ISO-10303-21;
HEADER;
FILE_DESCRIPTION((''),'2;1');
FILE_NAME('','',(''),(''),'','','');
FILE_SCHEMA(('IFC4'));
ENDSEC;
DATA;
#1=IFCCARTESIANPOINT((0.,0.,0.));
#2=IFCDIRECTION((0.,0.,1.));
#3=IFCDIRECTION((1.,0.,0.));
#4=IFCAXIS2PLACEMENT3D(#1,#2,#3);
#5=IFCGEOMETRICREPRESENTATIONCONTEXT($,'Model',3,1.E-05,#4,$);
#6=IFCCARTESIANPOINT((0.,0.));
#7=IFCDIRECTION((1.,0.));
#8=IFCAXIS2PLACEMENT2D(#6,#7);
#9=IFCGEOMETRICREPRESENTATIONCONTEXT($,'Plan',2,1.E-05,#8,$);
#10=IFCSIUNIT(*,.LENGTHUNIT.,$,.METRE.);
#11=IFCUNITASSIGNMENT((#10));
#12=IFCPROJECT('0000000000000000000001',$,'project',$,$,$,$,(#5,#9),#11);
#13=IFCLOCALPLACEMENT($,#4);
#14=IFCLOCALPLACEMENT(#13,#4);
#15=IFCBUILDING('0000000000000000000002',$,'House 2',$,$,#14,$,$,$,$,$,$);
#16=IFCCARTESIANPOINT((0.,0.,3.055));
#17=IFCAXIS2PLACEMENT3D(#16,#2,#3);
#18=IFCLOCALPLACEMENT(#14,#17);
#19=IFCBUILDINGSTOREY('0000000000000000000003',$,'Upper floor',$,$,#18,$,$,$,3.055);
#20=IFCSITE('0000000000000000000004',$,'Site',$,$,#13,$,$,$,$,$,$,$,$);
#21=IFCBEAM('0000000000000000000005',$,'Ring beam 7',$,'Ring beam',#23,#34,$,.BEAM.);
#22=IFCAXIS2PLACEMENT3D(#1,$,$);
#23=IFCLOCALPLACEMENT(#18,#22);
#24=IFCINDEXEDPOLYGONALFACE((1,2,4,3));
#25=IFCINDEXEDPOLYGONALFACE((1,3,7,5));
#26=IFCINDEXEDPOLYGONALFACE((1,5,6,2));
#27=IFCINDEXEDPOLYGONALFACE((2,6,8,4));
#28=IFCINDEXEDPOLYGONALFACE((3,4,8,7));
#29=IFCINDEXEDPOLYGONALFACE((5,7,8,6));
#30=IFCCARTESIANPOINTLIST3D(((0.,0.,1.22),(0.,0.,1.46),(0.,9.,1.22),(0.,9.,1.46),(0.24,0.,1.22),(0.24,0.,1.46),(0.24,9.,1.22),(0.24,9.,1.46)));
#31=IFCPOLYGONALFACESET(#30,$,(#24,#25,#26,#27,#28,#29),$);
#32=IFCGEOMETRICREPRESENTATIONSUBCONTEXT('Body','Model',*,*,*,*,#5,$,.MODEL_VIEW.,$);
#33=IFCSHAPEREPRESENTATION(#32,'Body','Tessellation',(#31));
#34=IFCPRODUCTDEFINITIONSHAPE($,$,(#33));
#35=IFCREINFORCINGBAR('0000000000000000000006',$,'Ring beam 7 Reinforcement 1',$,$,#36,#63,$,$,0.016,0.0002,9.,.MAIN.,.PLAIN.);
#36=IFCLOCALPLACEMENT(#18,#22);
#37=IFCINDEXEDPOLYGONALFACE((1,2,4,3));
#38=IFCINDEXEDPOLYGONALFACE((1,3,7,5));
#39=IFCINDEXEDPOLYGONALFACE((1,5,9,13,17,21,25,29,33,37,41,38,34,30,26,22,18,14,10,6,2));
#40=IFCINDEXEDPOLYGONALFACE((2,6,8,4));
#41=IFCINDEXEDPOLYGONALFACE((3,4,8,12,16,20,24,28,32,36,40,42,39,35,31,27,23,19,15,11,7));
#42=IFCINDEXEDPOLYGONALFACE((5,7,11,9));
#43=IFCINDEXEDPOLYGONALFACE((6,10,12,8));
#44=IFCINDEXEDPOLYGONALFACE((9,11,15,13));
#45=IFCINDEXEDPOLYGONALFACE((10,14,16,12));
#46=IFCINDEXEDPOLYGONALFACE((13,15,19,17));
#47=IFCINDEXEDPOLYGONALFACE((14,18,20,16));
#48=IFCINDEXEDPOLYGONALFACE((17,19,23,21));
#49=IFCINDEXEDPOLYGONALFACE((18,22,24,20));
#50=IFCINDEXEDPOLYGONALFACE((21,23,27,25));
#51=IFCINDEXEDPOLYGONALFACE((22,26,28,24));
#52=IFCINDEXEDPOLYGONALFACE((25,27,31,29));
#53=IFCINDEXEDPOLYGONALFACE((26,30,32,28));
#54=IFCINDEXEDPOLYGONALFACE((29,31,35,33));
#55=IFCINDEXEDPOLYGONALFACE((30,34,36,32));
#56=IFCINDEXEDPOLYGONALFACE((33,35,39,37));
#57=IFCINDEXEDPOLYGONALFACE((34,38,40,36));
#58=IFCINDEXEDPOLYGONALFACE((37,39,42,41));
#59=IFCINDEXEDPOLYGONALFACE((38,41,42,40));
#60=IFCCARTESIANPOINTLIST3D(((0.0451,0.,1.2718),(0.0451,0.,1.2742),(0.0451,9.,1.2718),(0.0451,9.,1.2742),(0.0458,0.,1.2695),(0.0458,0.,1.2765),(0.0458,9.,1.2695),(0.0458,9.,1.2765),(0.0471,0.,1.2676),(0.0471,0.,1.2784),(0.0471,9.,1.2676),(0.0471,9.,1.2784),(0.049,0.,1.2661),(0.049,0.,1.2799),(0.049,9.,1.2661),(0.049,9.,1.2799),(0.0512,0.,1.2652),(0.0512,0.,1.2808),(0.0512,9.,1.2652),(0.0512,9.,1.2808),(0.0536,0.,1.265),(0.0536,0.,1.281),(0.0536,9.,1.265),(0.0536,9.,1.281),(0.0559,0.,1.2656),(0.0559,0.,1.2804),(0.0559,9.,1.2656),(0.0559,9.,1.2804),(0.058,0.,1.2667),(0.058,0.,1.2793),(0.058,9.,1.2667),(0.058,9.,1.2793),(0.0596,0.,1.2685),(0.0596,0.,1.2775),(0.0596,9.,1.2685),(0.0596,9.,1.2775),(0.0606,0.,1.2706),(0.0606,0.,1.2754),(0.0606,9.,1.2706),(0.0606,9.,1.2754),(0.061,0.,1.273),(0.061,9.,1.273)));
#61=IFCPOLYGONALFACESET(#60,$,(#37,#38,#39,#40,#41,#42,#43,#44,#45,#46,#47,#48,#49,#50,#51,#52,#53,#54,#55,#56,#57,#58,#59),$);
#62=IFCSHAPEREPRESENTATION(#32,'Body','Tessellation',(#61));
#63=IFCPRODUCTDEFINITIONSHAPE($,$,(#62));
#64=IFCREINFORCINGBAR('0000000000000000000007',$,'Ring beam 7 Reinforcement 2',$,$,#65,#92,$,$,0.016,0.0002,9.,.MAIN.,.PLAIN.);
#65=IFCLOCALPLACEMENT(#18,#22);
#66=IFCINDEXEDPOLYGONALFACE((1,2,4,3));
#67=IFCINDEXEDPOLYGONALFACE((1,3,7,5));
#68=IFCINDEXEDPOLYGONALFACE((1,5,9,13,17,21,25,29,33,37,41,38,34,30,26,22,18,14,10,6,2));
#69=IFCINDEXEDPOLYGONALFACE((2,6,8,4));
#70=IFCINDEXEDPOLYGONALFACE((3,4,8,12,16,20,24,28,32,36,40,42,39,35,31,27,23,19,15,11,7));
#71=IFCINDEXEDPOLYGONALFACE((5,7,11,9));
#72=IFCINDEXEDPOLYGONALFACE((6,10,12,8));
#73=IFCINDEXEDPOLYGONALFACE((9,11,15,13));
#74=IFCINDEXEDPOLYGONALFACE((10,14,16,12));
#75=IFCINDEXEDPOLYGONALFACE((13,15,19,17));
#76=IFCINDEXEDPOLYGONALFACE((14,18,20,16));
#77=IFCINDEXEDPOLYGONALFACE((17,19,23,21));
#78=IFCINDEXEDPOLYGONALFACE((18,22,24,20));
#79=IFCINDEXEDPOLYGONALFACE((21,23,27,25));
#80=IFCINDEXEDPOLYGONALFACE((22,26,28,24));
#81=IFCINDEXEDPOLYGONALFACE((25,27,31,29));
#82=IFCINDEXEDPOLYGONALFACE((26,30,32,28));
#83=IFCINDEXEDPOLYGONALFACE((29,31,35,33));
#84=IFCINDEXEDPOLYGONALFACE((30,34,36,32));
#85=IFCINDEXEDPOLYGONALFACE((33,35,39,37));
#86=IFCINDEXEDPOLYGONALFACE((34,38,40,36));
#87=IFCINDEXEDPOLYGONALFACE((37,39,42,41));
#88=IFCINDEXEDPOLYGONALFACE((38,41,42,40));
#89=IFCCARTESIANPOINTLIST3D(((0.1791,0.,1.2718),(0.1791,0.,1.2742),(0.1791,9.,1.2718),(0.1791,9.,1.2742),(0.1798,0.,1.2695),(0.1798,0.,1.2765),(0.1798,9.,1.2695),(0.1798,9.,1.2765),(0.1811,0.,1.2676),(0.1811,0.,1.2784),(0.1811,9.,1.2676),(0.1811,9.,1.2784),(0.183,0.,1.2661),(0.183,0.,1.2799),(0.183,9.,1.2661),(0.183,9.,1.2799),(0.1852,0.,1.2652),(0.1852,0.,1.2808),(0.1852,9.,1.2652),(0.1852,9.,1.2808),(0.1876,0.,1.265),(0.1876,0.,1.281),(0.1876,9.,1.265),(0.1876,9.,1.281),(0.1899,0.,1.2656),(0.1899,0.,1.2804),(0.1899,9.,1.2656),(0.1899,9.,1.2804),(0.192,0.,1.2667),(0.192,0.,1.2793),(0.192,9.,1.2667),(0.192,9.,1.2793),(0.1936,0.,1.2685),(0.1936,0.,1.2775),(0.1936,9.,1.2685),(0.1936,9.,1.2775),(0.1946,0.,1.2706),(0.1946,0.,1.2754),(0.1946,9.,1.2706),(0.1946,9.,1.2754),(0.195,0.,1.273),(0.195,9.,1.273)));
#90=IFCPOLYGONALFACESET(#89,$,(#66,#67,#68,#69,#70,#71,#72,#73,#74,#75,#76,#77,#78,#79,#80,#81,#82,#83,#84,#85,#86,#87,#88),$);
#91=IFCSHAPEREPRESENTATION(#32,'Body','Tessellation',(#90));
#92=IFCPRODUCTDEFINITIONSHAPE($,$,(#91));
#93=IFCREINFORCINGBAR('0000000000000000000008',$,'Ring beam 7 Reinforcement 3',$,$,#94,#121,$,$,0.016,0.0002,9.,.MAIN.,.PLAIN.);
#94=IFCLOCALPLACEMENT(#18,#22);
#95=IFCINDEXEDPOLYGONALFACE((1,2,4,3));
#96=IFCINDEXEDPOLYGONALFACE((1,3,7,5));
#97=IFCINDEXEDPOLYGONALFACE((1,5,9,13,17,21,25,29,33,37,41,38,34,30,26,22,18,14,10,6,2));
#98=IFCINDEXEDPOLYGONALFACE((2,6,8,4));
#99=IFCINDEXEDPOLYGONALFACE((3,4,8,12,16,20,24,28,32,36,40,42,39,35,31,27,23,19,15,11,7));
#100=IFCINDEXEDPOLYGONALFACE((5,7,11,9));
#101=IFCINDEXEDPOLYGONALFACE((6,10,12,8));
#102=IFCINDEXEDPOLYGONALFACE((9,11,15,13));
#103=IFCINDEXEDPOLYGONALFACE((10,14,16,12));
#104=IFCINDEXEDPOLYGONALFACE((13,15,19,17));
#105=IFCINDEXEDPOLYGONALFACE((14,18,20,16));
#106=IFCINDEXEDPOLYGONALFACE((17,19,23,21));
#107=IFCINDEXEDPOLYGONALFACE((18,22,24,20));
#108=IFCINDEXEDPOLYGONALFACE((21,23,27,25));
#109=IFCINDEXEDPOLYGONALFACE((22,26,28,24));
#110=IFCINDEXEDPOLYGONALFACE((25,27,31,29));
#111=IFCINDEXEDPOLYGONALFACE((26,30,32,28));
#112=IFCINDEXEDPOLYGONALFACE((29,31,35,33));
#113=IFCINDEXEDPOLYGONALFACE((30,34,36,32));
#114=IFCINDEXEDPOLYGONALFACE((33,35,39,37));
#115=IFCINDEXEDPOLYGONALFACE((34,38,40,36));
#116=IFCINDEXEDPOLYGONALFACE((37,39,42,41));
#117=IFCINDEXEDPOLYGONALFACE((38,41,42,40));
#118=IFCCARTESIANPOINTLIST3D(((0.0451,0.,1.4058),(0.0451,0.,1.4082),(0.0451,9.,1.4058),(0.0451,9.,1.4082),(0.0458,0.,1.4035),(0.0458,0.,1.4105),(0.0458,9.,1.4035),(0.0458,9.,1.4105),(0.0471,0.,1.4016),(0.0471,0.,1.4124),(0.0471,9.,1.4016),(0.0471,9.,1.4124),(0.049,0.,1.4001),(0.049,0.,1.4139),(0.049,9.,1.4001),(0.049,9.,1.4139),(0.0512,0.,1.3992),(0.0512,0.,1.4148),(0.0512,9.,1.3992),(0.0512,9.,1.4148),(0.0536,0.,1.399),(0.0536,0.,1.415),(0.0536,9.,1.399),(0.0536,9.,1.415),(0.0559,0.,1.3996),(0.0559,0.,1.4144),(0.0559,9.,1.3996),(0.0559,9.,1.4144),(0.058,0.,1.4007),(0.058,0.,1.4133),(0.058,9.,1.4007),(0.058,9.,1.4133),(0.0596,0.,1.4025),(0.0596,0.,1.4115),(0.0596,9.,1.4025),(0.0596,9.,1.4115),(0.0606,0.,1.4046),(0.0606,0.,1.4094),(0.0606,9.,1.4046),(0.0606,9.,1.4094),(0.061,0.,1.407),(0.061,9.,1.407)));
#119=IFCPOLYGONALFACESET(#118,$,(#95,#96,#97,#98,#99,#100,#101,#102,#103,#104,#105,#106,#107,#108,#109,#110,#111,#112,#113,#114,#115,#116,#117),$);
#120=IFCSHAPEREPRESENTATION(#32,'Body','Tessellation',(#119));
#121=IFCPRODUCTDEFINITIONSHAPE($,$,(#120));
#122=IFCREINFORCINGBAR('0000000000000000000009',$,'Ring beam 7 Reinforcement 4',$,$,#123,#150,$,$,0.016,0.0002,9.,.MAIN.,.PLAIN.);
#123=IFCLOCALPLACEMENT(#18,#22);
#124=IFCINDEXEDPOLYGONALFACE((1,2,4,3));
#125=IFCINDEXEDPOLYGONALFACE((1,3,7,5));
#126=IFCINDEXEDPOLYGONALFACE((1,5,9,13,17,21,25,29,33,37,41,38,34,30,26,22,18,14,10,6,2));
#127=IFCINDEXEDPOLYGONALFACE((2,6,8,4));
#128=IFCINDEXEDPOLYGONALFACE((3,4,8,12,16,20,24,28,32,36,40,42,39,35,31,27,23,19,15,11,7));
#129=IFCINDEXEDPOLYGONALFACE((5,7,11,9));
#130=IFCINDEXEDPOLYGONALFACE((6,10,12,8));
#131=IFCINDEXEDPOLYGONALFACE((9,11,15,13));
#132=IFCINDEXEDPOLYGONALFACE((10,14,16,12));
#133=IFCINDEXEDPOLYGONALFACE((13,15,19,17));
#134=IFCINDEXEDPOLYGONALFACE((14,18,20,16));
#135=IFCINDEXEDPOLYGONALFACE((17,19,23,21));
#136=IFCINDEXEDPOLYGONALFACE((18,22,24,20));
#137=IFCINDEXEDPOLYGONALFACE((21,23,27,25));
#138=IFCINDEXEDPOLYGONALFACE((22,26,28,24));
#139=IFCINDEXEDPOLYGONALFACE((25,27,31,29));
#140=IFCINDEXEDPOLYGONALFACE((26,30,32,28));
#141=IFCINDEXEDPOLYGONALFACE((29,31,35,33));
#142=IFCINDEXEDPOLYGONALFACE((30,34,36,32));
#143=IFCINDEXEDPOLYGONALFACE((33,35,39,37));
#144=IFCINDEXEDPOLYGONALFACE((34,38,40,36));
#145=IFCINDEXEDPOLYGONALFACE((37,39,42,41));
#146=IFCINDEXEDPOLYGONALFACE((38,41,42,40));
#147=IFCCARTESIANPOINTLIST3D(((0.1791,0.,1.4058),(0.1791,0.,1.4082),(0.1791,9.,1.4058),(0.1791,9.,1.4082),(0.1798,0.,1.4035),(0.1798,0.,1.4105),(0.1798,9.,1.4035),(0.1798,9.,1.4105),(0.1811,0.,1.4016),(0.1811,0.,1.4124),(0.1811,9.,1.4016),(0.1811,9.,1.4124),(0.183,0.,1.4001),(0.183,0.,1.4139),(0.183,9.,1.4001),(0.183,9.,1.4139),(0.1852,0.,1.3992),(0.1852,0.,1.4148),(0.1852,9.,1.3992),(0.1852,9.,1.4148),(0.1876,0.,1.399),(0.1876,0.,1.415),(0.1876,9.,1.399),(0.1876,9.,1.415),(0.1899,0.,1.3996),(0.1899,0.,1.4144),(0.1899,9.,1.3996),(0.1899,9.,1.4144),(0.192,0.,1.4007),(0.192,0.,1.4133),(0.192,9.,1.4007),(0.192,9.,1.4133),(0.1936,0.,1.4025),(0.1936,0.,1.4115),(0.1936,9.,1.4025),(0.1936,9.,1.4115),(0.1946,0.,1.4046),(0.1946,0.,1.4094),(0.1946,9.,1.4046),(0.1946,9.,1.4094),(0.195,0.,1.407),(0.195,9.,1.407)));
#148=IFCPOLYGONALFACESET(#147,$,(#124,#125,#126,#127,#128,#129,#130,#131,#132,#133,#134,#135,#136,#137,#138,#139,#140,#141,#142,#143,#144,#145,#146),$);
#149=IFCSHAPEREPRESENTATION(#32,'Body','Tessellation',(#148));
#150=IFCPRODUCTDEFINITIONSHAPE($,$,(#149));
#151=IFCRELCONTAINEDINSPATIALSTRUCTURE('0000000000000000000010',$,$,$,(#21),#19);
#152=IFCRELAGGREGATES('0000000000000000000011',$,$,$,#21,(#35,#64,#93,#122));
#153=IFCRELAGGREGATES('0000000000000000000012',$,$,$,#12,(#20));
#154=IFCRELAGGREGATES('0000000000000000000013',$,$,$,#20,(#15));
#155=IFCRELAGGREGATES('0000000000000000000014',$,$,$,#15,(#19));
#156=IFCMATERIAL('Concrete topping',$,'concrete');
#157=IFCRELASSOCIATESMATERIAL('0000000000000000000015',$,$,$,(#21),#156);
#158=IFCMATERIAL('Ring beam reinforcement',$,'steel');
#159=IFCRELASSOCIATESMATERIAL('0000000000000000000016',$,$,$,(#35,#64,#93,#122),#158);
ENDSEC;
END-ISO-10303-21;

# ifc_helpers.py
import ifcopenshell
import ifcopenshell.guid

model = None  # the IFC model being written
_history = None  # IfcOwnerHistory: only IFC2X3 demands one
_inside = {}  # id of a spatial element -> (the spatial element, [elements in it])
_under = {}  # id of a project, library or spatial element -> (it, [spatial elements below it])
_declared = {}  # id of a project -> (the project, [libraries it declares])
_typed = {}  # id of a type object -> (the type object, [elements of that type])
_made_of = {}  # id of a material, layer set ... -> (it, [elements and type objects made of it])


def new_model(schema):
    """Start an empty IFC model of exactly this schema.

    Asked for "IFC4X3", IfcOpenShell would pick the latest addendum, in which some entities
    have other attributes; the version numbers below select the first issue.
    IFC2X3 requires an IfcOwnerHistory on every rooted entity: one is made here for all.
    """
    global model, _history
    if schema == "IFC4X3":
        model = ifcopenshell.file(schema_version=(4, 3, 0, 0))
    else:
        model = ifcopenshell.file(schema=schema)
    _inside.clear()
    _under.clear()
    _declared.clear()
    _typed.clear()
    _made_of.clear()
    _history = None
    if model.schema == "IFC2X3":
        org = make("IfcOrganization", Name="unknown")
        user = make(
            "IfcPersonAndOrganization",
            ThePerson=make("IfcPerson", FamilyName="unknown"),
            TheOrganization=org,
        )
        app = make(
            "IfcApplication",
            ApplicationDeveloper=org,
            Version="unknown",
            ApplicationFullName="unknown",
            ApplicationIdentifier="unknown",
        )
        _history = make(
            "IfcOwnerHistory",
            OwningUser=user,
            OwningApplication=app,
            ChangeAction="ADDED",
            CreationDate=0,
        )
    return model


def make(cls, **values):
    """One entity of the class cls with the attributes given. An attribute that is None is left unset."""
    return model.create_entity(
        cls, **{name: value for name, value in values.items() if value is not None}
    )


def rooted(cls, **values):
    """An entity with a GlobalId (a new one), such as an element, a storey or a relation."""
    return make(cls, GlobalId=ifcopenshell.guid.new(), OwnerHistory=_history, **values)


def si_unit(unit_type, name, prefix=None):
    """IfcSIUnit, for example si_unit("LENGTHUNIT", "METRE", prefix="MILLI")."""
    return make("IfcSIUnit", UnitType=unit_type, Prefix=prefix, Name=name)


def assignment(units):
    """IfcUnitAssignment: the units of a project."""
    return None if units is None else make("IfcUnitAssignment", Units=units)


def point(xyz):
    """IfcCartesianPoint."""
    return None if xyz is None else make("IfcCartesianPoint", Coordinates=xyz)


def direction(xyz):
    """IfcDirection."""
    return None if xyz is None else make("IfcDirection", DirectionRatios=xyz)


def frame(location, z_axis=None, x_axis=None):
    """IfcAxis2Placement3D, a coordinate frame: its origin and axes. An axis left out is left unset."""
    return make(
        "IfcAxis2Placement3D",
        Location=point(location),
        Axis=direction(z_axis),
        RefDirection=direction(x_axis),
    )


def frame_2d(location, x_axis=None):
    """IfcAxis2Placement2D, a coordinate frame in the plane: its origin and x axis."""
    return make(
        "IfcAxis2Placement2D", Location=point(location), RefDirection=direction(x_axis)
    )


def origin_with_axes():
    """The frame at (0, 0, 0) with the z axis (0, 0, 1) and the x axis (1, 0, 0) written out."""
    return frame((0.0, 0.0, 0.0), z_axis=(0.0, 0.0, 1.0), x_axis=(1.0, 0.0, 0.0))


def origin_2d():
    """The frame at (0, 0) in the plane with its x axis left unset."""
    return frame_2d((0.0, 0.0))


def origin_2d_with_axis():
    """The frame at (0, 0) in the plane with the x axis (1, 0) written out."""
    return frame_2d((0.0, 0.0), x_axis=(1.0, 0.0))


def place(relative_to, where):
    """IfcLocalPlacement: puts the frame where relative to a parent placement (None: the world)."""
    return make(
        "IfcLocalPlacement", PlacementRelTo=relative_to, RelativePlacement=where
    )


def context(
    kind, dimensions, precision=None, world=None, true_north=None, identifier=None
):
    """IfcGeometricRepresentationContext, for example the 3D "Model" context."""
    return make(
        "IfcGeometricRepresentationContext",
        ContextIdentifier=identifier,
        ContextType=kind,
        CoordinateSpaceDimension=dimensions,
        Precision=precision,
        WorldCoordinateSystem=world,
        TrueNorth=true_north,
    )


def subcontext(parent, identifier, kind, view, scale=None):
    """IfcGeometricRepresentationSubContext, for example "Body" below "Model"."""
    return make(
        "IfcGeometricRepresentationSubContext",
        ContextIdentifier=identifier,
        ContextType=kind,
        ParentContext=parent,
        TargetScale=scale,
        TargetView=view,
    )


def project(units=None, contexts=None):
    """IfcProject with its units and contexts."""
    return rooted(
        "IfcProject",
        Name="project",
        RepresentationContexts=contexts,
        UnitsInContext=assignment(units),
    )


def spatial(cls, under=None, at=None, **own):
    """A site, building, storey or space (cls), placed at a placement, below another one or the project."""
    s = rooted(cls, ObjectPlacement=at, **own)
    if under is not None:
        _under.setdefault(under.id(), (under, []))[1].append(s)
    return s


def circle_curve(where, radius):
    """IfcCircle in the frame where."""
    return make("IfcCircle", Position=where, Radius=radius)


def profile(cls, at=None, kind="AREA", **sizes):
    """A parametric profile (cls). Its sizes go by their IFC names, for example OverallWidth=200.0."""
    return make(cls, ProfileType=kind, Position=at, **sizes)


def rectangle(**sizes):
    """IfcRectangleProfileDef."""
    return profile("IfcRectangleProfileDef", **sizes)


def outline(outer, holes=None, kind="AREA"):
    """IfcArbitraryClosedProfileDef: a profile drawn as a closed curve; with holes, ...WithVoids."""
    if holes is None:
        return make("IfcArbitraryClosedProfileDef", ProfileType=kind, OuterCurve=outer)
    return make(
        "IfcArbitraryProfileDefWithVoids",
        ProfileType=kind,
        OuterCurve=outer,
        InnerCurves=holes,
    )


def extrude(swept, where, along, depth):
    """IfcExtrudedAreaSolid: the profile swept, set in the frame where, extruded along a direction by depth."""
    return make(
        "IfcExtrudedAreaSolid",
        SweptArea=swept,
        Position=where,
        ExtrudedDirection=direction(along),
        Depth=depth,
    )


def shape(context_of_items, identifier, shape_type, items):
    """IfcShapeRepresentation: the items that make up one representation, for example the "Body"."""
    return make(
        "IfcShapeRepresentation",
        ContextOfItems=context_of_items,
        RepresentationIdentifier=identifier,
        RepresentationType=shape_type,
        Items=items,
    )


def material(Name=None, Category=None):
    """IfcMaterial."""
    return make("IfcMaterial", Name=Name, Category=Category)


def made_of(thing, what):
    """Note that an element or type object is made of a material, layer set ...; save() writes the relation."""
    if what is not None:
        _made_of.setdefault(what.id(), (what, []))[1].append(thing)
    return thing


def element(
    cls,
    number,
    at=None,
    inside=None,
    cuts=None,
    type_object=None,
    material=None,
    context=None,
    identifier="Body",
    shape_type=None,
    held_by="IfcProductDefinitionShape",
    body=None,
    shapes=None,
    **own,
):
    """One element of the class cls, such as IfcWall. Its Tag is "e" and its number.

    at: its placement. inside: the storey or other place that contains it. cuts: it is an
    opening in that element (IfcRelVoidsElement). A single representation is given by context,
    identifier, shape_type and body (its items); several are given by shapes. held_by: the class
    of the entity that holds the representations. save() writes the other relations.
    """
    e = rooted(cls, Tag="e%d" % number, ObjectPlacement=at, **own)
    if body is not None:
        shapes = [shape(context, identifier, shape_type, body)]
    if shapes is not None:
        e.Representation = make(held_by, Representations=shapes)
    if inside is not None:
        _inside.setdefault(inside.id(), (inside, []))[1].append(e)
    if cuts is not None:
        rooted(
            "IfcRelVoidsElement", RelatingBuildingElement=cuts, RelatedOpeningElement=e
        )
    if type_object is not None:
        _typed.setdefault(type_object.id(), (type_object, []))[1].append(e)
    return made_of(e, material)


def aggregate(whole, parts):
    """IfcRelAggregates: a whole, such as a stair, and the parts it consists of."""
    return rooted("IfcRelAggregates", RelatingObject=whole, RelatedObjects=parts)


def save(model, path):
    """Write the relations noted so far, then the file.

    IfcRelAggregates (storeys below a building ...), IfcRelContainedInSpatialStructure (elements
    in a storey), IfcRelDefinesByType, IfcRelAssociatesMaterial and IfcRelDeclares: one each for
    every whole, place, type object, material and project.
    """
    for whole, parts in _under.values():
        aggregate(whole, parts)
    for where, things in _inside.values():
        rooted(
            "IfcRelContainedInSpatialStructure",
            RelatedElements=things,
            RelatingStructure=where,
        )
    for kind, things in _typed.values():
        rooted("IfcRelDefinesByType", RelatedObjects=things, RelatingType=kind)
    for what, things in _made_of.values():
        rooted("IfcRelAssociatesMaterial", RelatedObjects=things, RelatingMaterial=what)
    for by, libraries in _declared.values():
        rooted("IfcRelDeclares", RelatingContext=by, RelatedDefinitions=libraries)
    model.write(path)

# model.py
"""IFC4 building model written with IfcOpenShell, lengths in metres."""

from ifc_helpers import new_model, si_unit, frame, origin_with_axes, origin_2d, origin_2d_with_axis, place, context, subcontext, project, spatial, circle_curve, rectangle, outline, extrude, material, element, aggregate, save


model = new_model("IFC4")

# Units and contexts
model_context = context("Model", 3, precision=1e-05, world=origin_with_axes())
plan_context = context("Plan", 2, precision=1e-05, world=origin_2d_with_axis())
body_context_1 = subcontext(model_context, "Body", "Model", "MODEL_VIEW")
ifc_project = project(units=[si_unit("LENGTHUNIT", "METRE")], contexts=[model_context, plan_context])

# Site, building, storey
site_placement = place(None, origin_with_axes())
site = spatial("IfcSite", under=ifc_project, at=site_placement, Name="Site")
building_placement = place(site_placement, origin_with_axes())
building = spatial("IfcBuilding", under=site, at=building_placement, Name="House 2")
storey_placement = place(building_placement, frame((0.0, 0.0, 3.055), z_axis=(0.0, 0.0, 1.0), x_axis=(1.0, 0.0, 0.0)))
storey = spatial("IfcBuildingStorey", under=building, at=storey_placement, Name="Upper floor", Elevation=3.055)

# Beam
ifc_material_1 = material(Name="Concrete topping", Category="concrete")
beam_1_placement = place(storey_placement, frame((0.12, 9.0, 1.34), z_axis=(0.0, 0.0, 1.0), x_axis=(0.0, -1.0, 0.0)))
beam_1 = element("IfcBeam", 1, at=beam_1_placement, inside=storey, material=ifc_material_1, Name="Ring beam 7", ObjectType="Ring beam", PredefinedType="BEAM", context=body_context_1, shape_type="SweptSolid", body=[
    extrude(rectangle(XDim=0.24, YDim=0.24), frame((0.0, 0.0, 0.0), z_axis=(1.0, 0.0, 0.0), x_axis=(0.0, 1.0, 0.0)), (0.0, 0.0, 1.0), 9.0),
])

# Reinforcing bars
ifc_material_2 = material(Name="Ring beam reinforcement", Category="steel")
reinforcing_bar_1_placement = place(beam_1_placement, frame((0.0, -0.067, -0.067), z_axis=(0.0, 0.0, 1.0), x_axis=(1.0, 0.0, 0.0)))
reinforcing_bar_1 = element("IfcReinforcingBar", 2, at=reinforcing_bar_1_placement, material=ifc_material_2, Name="Ring beam 7 Reinforcement 1", BarLength=9.0, BarSurface="PLAIN", CrossSectionArea=0.0002, NominalDiameter=0.016, PredefinedType="MAIN", context=body_context_1, shape_type="SweptSolid", body=[
    extrude(outline(circle_curve(origin_2d(), 0.008)), frame((0.0, 0.0, 0.0), z_axis=(1.0, 0.0, 0.0), x_axis=(0.0, 1.0, 0.0)), (0.0, 0.0, 1.0), 9.0),
])
reinforcing_bar_2_placement = place(beam_1_placement, frame((0.0, 0.067, -0.067), z_axis=(0.0, 0.0, 1.0), x_axis=(1.0, 0.0, 0.0)))
reinforcing_bar_2 = element("IfcReinforcingBar", 3, at=reinforcing_bar_2_placement, material=ifc_material_2, Name="Ring beam 7 Reinforcement 2", BarLength=9.0, BarSurface="PLAIN", CrossSectionArea=0.0002, NominalDiameter=0.016, PredefinedType="MAIN", context=body_context_1, shape_type="SweptSolid", body=[
    extrude(outline(circle_curve(origin_2d(), 0.008)), frame((0.0, 0.0, 0.0), z_axis=(1.0, 0.0, 0.0), x_axis=(0.0, 1.0, 0.0)), (0.0, 0.0, 1.0), 9.0),
])
reinforcing_bar_3_placement = place(beam_1_placement, frame((0.0, -0.067, 0.067), z_axis=(0.0, 0.0, 1.0), x_axis=(1.0, 0.0, 0.0)))
reinforcing_bar_3 = element("IfcReinforcingBar", 4, at=reinforcing_bar_3_placement, material=ifc_material_2, Name="Ring beam 7 Reinforcement 3", BarLength=9.0, BarSurface="PLAIN", CrossSectionArea=0.0002, NominalDiameter=0.016, PredefinedType="MAIN", context=body_context_1, shape_type="SweptSolid", body=[
    extrude(outline(circle_curve(origin_2d(), 0.008)), frame((0.0, 0.0, 0.0), z_axis=(1.0, 0.0, 0.0), x_axis=(0.0, 1.0, 0.0)), (0.0, 0.0, 1.0), 9.0),
])
reinforcing_bar_4_placement = place(beam_1_placement, frame((0.0, 0.067, 0.067), z_axis=(0.0, 0.0, 1.0), x_axis=(1.0, 0.0, 0.0)))
reinforcing_bar_4 = element("IfcReinforcingBar", 5, at=reinforcing_bar_4_placement, material=ifc_material_2, Name="Ring beam 7 Reinforcement 4", BarLength=9.0, BarSurface="PLAIN", CrossSectionArea=0.0002, NominalDiameter=0.016, PredefinedType="MAIN", context=body_context_1, shape_type="SweptSolid", body=[
    extrude(outline(circle_curve(origin_2d(), 0.008)), frame((0.0, 0.0, 0.0), z_axis=(1.0, 0.0, 0.0), x_axis=(0.0, 1.0, 0.0)), (0.0, 0.0, 1.0), 9.0),
])
aggregate(beam_1, [reinforcing_bar_1, reinforcing_bar_2, reinforcing_bar_3, reinforcing_bar_4])

save(model, "model.ifc")
